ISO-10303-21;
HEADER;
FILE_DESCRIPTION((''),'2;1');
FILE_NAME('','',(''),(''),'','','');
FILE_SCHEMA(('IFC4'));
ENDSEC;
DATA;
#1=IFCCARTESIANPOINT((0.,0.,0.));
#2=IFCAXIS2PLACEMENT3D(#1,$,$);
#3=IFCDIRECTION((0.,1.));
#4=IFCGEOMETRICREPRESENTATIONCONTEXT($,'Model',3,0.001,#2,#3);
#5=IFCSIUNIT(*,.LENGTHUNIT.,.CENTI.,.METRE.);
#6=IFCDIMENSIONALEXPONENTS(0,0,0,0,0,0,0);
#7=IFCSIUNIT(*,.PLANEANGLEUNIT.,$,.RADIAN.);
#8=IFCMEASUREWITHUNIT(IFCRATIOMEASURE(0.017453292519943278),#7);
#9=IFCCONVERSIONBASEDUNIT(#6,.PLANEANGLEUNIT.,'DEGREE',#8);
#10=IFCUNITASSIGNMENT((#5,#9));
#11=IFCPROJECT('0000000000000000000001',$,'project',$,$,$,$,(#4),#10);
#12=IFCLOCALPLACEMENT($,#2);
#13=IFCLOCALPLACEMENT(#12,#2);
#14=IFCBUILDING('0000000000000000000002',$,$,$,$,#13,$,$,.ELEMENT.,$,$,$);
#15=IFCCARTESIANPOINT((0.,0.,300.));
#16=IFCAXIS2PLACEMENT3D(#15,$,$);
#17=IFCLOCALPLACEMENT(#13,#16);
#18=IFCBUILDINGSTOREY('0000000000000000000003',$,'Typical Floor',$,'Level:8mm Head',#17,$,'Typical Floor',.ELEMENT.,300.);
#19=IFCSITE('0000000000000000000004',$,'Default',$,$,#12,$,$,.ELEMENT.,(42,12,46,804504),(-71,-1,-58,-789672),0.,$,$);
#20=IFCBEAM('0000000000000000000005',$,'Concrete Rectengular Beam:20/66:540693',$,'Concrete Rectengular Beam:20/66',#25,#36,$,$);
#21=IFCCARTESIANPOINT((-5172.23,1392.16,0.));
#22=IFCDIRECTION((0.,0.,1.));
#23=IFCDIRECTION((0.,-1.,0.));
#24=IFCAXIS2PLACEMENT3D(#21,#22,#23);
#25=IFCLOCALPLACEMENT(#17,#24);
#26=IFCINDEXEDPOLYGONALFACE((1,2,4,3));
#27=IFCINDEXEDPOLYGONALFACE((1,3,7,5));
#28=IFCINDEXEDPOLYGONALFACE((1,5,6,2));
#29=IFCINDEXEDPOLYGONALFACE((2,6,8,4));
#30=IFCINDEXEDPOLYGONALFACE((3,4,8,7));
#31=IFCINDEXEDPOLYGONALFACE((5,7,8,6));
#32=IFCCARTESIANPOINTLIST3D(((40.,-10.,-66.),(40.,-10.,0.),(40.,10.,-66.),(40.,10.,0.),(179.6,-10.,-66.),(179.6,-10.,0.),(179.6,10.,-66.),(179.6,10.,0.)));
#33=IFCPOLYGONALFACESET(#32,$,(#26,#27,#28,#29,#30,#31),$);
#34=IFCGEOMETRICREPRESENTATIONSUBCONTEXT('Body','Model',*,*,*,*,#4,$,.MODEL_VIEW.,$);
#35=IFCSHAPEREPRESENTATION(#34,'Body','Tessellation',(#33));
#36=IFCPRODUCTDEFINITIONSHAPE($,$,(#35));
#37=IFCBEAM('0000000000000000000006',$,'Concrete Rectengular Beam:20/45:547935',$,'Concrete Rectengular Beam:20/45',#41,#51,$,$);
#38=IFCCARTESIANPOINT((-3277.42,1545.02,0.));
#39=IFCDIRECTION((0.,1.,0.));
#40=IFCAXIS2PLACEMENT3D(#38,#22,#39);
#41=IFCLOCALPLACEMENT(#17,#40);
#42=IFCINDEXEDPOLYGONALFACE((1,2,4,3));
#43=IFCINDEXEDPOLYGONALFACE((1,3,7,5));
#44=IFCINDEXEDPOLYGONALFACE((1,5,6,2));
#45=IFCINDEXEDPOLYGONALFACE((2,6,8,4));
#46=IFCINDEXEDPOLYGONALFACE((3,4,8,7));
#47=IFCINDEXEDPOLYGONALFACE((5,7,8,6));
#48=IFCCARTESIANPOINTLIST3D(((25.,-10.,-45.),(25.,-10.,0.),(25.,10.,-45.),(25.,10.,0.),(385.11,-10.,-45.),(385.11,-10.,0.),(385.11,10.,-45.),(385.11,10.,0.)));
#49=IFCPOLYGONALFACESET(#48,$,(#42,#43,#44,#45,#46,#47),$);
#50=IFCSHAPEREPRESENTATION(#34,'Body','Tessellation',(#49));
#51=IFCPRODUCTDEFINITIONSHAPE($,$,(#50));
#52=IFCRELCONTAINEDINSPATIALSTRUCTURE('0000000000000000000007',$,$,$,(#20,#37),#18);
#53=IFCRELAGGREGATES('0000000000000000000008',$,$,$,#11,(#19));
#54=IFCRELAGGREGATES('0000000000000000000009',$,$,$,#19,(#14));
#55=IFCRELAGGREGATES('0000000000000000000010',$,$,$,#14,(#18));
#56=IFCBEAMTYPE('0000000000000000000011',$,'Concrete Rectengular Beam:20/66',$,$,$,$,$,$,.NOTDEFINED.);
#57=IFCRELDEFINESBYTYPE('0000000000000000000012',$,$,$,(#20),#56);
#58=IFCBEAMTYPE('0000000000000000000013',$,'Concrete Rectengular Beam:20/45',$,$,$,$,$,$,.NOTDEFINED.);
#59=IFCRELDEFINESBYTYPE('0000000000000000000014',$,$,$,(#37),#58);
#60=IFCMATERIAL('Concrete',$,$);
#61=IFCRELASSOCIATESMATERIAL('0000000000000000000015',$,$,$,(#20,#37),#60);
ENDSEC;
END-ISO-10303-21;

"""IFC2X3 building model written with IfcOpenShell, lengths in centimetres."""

from ifc_helpers import new_model, entity, si_unit, converted_unit, direction, frame, frame_2d, origin, place, context, subcontext, project, spatial, rectangle, extrude, material, type_object, element, save


model = new_model("IFC2X3")

# Units and contexts
model_context = context("Model", 3, precision=0.001, world=origin(), true_north=direction((0.0, 1.0)))
body_context = subcontext(model_context, "Body", "Model", "MODEL_VIEW")
ifc_project = project(units=[si_unit("LENGTHUNIT", "METRE", prefix="CENTI"), converted_unit("PLANEANGLEUNIT", "DEGREE", entity("IfcRatioMeasure", 0.017453292519943278), si_unit("PLANEANGLEUNIT", "RADIAN"), dimensions=[0, 0, 0, 0, 0, 0, 0])], contexts=[model_context])

# Site, building, storey
site_placement = place(None, origin())
site = spatial("IfcSite", under=ifc_project, at=site_placement, Name="Default", CompositionType="ELEMENT", RefLatitude=(42, 12, 46, 804504), RefLongitude=(-71, -1, -58, -789672), RefElevation=0.0)
building_placement = place(site_placement, origin())
building = spatial("IfcBuilding", under=site, at=building_placement, CompositionType="ELEMENT")
storey_placement = place(building_placement, frame((0.0, 0.0, 300.0)))
storey = spatial("IfcBuildingStorey", under=building, at=storey_placement, Name="Typical Floor", ObjectType="Level:8mm Head", LongName="Typical Floor", CompositionType="ELEMENT", Elevation=300.0)

# Beams
ifc_material = material(Name="Concrete")
beam_type_1 = type_object("IfcBeamType", Name="Concrete Rectengular Beam:20/66", PredefinedType="NOTDEFINED")
beam_1_placement = place(storey_placement, frame((-5172.23, 1392.16, 0.0), z_axis=(0.0, 0.0, 1.0), x_axis=(0.0, -1.0, 0.0)))
element("IfcBeam", 1, at=beam_1_placement, inside=storey, type_object=beam_type_1, material=ifc_material, Name="Concrete Rectengular Beam:20/66:540693", ObjectType="Concrete Rectengular Beam:20/66", context=body_context, shape_type="SweptSolid", body=[
    extrude(rectangle(XDim=66.0, YDim=20.0, at=frame_2d((0.0, 0.0), x_axis=(1.0, 0.0))), frame((40.0, 0.0, -33.0), z_axis=(1.0, 0.0, 0.0), x_axis=(0.0, 0.0, -1.0)), (0.0, 0.0, 1.0), 139.6),
])
beam_type_2 = type_object("IfcBeamType", Name="Concrete Rectengular Beam:20/45", PredefinedType="NOTDEFINED")
beam_2_placement = place(storey_placement, frame((-3277.42, 1545.02, 0.0), z_axis=(0.0, 0.0, 1.0), x_axis=(0.0, 1.0, 0.0)))
element("IfcBeam", 2, at=beam_2_placement, inside=storey, type_object=beam_type_2, material=ifc_material, Name="Concrete Rectengular Beam:20/45:547935", ObjectType="Concrete Rectengular Beam:20/45", context=body_context, shape_type="SweptSolid", body=[
    extrude(rectangle(XDim=45.0, YDim=20.0, at=frame_2d((0.0, 0.0), x_axis=(1.0, 0.0))), frame((25.0, 0.0, -22.5), z_axis=(1.0, 0.0, 0.0), x_axis=(0.0, 0.0, -1.0)), (0.0, 0.0, 1.0), 360.11),
])

save(model, "model.ifc")
